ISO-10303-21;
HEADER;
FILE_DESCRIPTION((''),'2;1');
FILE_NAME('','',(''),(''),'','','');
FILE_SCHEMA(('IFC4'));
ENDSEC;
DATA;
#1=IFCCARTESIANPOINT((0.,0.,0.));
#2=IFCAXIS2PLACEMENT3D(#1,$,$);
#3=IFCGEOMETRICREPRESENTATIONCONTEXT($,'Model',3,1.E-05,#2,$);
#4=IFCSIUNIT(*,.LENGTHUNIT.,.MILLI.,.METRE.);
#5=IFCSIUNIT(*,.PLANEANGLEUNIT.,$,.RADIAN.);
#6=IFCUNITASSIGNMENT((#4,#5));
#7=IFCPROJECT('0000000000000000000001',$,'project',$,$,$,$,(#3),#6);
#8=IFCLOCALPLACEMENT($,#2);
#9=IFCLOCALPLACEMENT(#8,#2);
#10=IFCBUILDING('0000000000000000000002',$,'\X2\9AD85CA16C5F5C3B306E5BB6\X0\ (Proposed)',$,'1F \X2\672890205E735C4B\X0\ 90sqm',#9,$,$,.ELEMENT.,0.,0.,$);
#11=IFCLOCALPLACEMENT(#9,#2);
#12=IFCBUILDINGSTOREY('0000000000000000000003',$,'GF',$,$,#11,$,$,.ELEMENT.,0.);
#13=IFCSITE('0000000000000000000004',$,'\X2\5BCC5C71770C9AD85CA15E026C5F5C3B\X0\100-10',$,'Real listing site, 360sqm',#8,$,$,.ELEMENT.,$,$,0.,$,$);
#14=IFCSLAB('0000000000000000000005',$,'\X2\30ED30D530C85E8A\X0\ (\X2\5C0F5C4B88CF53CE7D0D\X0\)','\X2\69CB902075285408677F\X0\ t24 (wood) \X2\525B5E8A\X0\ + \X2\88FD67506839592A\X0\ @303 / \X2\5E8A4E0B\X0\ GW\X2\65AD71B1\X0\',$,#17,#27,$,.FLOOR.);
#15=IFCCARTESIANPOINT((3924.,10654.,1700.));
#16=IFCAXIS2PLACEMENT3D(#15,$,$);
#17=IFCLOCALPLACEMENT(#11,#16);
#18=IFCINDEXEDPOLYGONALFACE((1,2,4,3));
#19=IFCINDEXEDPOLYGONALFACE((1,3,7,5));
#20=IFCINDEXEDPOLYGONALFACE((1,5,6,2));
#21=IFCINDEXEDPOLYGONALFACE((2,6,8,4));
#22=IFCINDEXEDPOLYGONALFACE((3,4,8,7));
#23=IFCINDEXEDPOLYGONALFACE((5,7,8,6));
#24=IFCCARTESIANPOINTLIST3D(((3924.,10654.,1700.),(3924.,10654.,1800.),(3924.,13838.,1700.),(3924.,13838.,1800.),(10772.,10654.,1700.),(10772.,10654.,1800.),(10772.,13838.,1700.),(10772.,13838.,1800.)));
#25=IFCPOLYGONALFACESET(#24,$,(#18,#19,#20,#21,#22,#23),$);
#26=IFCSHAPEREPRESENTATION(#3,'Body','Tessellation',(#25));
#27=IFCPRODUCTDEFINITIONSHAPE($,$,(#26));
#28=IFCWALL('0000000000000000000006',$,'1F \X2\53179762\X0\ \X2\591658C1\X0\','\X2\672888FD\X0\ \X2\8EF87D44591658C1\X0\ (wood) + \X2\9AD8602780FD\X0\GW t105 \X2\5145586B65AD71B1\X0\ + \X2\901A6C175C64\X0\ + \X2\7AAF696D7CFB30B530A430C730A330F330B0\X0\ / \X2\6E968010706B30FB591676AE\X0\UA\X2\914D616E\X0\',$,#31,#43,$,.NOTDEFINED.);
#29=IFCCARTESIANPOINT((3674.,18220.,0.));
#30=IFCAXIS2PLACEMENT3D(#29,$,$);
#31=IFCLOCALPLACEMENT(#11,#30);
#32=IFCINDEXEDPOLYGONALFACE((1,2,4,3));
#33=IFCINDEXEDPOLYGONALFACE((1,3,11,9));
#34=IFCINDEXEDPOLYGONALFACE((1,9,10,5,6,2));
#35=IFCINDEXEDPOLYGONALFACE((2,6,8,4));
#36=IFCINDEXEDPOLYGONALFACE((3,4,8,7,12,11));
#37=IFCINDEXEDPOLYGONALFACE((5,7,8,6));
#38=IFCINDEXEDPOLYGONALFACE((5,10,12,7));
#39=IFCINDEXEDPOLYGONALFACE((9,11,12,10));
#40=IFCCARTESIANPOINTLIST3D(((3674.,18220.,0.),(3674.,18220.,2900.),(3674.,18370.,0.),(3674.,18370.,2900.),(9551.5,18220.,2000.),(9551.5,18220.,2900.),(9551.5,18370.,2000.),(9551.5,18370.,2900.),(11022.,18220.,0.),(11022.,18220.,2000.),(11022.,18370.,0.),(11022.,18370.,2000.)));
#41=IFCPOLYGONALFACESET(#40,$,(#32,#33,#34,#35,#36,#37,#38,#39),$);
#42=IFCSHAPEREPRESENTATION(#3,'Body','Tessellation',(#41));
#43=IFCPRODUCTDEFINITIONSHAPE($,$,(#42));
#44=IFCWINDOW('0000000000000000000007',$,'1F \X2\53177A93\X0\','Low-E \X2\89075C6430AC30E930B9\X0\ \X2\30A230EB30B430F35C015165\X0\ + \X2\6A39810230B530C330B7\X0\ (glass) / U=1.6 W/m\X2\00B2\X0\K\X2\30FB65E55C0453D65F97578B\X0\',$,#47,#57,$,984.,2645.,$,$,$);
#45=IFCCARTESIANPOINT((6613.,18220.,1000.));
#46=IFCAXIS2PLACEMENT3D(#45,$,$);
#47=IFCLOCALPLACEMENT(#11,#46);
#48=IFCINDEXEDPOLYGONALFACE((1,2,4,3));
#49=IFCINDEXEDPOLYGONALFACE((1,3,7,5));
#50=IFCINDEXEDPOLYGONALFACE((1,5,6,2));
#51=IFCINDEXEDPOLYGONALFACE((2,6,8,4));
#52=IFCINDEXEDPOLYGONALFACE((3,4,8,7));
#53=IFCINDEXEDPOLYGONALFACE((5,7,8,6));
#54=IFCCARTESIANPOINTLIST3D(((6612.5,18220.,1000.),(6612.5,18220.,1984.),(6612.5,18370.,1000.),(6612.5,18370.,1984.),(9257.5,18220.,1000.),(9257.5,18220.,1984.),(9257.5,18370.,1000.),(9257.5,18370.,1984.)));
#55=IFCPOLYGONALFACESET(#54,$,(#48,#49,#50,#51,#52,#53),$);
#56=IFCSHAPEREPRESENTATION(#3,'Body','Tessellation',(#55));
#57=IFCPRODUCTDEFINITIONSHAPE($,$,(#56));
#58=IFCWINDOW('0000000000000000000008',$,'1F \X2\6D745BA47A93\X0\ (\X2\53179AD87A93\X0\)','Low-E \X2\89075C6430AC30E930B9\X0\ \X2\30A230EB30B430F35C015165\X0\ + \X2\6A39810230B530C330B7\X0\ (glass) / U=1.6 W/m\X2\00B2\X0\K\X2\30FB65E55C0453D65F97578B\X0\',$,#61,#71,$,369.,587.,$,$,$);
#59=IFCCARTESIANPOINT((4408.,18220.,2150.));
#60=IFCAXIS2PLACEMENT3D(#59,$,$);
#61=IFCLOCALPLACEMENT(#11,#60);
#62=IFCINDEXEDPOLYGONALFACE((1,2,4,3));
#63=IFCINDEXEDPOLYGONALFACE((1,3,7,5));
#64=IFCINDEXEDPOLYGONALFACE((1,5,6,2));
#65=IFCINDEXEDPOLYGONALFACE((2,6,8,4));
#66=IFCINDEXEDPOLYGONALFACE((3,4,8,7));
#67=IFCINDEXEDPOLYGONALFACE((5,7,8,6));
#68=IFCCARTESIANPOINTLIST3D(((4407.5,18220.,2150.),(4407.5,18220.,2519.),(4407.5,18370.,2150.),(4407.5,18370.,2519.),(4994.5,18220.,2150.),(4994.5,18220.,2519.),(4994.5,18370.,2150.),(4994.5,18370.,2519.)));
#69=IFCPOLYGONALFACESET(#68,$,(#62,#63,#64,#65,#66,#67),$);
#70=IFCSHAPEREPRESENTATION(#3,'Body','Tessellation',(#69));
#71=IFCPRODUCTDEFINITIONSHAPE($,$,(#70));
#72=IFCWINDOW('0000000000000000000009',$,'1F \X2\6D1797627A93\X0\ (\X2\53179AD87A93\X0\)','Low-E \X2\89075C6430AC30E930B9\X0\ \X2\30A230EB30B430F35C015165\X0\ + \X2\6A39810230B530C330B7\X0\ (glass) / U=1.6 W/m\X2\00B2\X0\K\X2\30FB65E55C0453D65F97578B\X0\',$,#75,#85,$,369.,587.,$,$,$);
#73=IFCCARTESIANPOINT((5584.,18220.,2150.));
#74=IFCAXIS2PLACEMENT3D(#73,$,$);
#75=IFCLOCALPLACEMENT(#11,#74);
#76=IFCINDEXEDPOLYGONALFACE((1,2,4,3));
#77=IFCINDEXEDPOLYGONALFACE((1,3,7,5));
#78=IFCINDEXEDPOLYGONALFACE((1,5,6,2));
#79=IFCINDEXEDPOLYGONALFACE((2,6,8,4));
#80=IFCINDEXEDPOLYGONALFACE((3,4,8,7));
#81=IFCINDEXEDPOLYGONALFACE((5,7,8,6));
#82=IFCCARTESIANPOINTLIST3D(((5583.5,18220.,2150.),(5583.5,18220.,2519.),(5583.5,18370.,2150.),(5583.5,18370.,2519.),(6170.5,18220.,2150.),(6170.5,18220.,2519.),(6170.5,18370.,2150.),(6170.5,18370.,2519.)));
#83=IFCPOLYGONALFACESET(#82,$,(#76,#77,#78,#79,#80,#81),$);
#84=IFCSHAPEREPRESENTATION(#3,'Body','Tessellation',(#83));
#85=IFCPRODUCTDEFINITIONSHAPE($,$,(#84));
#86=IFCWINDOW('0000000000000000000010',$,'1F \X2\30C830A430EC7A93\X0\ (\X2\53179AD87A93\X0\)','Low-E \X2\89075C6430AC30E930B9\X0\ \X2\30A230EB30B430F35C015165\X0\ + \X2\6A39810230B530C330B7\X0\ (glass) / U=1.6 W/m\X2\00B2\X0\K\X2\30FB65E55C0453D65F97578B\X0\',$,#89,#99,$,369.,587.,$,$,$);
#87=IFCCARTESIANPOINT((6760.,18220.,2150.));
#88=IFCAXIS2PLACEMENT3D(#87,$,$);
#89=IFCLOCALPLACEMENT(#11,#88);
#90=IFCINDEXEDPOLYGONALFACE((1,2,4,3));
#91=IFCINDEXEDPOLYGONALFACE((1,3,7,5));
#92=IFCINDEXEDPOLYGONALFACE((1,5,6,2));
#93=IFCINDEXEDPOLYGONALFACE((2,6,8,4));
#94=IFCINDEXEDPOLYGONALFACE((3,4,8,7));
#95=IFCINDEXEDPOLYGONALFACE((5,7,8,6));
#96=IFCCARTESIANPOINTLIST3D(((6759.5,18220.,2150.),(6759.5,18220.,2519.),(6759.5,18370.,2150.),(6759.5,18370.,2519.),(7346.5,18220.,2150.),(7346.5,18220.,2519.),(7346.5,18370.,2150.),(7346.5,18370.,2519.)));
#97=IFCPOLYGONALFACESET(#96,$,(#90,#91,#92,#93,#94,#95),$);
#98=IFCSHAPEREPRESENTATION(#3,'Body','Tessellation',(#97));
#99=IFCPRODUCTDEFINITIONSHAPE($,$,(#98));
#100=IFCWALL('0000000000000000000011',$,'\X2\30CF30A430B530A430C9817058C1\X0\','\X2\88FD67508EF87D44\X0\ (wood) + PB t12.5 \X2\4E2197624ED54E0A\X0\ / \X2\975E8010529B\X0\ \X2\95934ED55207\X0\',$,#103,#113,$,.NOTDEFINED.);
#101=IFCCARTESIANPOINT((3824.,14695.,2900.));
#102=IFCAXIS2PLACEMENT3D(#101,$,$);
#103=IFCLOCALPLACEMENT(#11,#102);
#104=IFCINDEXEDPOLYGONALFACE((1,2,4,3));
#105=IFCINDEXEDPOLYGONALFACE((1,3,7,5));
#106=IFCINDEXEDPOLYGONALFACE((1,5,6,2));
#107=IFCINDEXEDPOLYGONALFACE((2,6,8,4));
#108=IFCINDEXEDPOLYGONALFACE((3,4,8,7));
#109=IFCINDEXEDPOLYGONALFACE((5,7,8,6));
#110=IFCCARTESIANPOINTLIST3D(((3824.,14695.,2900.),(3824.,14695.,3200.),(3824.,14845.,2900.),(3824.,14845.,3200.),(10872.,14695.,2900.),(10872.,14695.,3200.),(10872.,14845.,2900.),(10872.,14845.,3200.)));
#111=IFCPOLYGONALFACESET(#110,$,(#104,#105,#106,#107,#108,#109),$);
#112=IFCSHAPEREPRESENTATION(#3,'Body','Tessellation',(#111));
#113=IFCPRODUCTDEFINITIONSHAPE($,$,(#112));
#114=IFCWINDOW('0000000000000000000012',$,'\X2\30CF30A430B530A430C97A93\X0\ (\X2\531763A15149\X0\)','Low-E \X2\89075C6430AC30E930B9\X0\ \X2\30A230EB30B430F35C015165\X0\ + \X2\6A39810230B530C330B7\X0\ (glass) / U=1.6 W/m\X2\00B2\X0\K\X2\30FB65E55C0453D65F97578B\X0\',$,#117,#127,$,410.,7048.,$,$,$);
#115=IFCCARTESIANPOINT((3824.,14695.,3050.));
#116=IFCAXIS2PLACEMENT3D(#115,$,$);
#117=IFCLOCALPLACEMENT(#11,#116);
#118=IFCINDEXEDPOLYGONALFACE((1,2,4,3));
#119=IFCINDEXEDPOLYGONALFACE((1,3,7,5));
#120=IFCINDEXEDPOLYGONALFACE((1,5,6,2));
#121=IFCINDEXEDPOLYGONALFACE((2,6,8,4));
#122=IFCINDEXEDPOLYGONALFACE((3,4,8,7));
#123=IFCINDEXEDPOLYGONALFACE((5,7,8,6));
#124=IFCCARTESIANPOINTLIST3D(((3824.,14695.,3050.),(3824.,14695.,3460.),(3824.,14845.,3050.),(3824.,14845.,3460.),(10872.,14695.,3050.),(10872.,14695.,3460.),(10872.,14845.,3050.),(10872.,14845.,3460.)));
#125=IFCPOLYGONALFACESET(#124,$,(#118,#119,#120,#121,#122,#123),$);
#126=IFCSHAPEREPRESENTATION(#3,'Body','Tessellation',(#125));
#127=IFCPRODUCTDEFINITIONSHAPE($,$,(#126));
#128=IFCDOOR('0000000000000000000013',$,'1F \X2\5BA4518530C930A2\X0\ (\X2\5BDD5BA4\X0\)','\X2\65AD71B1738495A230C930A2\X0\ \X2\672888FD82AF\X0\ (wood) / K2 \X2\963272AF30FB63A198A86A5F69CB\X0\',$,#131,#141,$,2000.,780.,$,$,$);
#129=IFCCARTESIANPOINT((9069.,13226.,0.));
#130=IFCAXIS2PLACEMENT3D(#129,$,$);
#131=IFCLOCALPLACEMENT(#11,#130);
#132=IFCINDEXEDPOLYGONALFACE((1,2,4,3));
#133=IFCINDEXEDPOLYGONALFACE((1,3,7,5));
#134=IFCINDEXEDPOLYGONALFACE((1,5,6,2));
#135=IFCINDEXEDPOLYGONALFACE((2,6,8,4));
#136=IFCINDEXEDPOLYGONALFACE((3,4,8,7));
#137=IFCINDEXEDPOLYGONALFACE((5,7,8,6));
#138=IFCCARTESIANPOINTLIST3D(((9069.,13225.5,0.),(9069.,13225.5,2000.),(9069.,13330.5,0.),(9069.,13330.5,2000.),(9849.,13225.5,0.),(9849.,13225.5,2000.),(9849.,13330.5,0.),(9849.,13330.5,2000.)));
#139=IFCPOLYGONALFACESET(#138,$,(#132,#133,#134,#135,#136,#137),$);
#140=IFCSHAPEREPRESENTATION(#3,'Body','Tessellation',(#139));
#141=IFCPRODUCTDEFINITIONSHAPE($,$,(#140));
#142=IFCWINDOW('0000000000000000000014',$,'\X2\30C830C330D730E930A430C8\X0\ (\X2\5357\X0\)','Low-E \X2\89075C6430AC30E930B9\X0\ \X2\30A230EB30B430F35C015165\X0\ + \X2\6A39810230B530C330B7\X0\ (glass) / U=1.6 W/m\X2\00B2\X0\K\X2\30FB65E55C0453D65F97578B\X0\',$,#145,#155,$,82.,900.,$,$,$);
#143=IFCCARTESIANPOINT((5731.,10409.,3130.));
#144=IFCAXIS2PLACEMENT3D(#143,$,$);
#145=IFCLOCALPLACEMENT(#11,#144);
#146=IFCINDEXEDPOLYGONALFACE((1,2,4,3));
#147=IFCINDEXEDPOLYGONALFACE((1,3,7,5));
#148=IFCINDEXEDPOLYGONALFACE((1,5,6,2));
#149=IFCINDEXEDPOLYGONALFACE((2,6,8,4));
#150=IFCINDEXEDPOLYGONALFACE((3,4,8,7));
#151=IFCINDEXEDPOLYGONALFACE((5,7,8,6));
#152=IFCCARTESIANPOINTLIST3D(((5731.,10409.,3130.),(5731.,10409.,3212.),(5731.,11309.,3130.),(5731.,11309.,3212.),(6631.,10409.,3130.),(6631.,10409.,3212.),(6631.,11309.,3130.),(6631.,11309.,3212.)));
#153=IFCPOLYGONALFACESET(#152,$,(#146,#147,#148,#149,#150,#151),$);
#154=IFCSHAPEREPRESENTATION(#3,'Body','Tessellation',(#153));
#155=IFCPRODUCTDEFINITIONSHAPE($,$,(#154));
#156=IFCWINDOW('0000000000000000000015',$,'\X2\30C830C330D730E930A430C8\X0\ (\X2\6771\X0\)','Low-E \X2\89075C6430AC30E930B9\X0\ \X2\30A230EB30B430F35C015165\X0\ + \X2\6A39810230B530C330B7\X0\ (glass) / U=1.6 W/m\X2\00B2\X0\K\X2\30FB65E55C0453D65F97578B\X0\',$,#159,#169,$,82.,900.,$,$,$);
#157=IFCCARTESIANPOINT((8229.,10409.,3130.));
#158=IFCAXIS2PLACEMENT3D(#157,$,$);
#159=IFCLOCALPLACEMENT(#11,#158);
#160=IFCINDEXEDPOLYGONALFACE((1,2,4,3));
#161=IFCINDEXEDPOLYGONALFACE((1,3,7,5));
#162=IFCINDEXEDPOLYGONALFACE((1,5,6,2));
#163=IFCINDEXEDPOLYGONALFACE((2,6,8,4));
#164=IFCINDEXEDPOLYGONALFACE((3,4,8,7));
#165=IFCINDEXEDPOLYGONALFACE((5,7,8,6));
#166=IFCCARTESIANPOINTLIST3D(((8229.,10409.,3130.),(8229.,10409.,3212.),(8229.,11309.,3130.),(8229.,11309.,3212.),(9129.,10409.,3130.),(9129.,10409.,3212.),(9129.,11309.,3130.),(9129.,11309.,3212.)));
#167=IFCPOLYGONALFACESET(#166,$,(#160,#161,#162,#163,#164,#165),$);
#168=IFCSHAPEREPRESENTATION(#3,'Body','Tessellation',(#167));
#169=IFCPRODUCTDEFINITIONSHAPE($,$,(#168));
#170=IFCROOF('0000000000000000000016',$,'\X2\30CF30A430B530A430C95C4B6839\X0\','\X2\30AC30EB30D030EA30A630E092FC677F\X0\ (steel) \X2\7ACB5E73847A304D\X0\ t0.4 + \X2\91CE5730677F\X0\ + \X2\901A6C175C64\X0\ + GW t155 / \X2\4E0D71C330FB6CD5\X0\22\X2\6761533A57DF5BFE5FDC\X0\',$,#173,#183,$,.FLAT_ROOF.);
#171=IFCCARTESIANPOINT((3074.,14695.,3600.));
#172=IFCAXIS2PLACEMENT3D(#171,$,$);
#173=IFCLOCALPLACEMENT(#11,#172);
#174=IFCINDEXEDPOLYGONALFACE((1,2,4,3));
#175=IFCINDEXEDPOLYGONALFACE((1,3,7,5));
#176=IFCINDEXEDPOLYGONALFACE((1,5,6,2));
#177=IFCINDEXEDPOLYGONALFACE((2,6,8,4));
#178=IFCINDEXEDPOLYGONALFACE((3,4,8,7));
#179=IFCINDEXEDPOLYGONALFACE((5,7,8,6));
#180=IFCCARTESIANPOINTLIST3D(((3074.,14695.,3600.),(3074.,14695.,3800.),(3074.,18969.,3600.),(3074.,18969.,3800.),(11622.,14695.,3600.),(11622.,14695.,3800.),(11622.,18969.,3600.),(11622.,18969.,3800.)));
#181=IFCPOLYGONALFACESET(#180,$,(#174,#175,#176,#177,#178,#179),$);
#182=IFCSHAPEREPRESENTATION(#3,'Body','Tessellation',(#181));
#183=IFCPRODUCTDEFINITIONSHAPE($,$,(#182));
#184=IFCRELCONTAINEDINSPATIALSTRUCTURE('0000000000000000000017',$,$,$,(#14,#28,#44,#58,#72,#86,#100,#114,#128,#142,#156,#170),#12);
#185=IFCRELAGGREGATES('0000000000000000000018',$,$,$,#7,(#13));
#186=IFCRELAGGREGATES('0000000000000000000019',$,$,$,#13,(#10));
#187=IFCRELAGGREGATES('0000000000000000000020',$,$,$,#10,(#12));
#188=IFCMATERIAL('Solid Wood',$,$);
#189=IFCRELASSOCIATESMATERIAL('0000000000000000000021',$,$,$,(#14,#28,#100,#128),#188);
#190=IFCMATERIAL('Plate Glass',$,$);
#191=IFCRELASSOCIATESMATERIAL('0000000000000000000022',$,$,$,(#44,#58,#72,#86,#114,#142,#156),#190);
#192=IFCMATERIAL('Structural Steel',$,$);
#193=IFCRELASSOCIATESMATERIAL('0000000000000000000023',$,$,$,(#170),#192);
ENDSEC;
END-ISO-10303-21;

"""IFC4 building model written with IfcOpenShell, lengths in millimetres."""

from ifc_helpers import new_model, si_unit, frame, frame_2d, origin, place, context, project, spatial, rectangle, extrude, material, element, fill, save


model = new_model("IFC4")

# Units and contexts
model_context = context("Model", 3, precision=1e-05, world=origin())
ifc_project = project(units=[si_unit("LENGTHUNIT", "METRE", prefix="MILLI"), si_unit("PLANEANGLEUNIT", "RADIAN")], contexts=[model_context])

# Site, building, storey
site_placement = place(None, origin())
site = spatial("IfcSite", under=ifc_project, at=site_placement, Name="富山県高岡市江尻100-10", ObjectType="Real listing site, 360sqm", CompositionType="ELEMENT", RefElevation=0.0)
building_placement = place(site_placement, origin())
building = spatial("IfcBuilding", under=site, at=building_placement, Name="高岡江尻の家 (Proposed)", ObjectType="1F 木造平屋 90sqm", CompositionType="ELEMENT", ElevationOfRefHeight=0.0, ElevationOfTerrain=0.0)
storey_placement = place(building_placement, origin())
storey = spatial("IfcBuildingStorey", under=building, at=storey_placement, Name="GF", CompositionType="ELEMENT", Elevation=0.0)

# Slab
ifc_material_1 = material(Name="Solid Wood")
slab_placement = place(storey_placement, frame((3924.0, 10654.0, 1700.0)))
element("IfcSlab", 1, at=slab_placement, inside=storey, material=ifc_material_1, Name="ロフト床 (小屋裏収納)", Description="構造用合板 t24 (wood) 剛床 + 製材根太 @303 / 床下 GW断熱", PredefinedType="FLOOR", context=model_context, shape_type="SweptSolid", body=[
    extrude(rectangle(XDim=6848.0, YDim=3184.0, at=frame_2d((3424.0, 1592.0))), frame((3924.0, 10654.0, 1700.0)), (0.0, 0.0, 1.0), 100.0),
])

# Wall, openings, windows
wall_1_placement = place(storey_placement, frame((3674.0, 18220.0, 0.0)))
wall_1 = element("IfcWall", 2, at=wall_1_placement, inside=storey, material=ifc_material_1, Name="1F 北面 外壁", Description="木製 軸組外壁 (wood) + 高性能GW t105 充填断熱 + 通気層 + 窯業系サイディング / 準耐火・外皮UA配慮", PredefinedType="NOTDEFINED", context=model_context, shape_type="SweptSolid", body=[
    extrude(rectangle(XDim=7348.0, YDim=150.0, at=frame_2d((3674.0, 75.0))), frame((3674.0, 18220.0, 0.0)), (0.0, 0.0, 1.0), 2900.0),
])
opening_1_placement = place(storey_placement, frame((6613.0, 18220.0, 1000.0)))
opening_1 = element("IfcOpeningElement", 3, at=opening_1_placement, cuts=wall_1, PredefinedType="NOTDEFINED", context=model_context, shape_type="SweptSolid", body=[
    extrude(rectangle(XDim=2645.0, YDim=150.0, at=frame_2d((1322.0, 75.0))), frame((6613.0, 18220.0, 1000.0)), (0.0, 0.0, 1.0), 984.0),
])
opening_2_placement = place(storey_placement, frame((4408.0, 18220.0, 2150.0)))
opening_2 = element("IfcOpeningElement", 4, at=opening_2_placement, cuts=wall_1, PredefinedType="NOTDEFINED", context=model_context, shape_type="SweptSolid", body=[
    extrude(rectangle(XDim=587.0, YDim=150.0, at=frame_2d((293.0, 75.0))), frame((4408.0, 18220.0, 2150.0)), (0.0, 0.0, 1.0), 369.0),
])
opening_3_placement = place(storey_placement, frame((5584.0, 18220.0, 2150.0)))
opening_3 = element("IfcOpeningElement", 5, at=opening_3_placement, cuts=wall_1, PredefinedType="NOTDEFINED", context=model_context, shape_type="SweptSolid", body=[
    extrude(rectangle(XDim=587.0, YDim=150.0, at=frame_2d((293.0, 75.0))), frame((5584.0, 18220.0, 2150.0)), (0.0, 0.0, 1.0), 369.0),
])
opening_4_placement = place(storey_placement, frame((6760.0, 18220.0, 2150.0)))
opening_4 = element("IfcOpeningElement", 6, at=opening_4_placement, cuts=wall_1, PredefinedType="NOTDEFINED", context=model_context, shape_type="SweptSolid", body=[
    extrude(rectangle(XDim=587.0, YDim=150.0, at=frame_2d((293.0, 75.0))), frame((6760.0, 18220.0, 2150.0)), (0.0, 0.0, 1.0), 369.0),
])
ifc_material_2 = material(Name="Plate Glass")
window_1_placement = place(storey_placement, frame((6613.0, 18220.0, 1000.0)))
window_1 = element("IfcWindow", 7, at=window_1_placement, inside=storey, material=ifc_material_2, Name="1F 北窓", Description="Low-E 複層ガラス アルゴン封入 + 樹脂サッシ (glass) / U=1.6 W/m²K・日射取得型", OverallHeight=984.0, OverallWidth=2645.0, context=model_context, shape_type="SweptSolid", body=[
    extrude(rectangle(XDim=2645.0, YDim=150.0, at=frame_2d((1322.0, 75.0))), frame((6613.0, 18220.0, 1000.0)), (0.0, 0.0, 1.0), 984.0),
])
fill(opening_1, window_1)
window_2_placement = place(storey_placement, frame((4408.0, 18220.0, 2150.0)))
window_2 = element("IfcWindow", 8, at=window_2_placement, inside=storey, material=ifc_material_2, Name="1F 浴室窓 (北高窓)", Description="Low-E 複層ガラス アルゴン封入 + 樹脂サッシ (glass) / U=1.6 W/m²K・日射取得型", OverallHeight=369.0, OverallWidth=587.0, context=model_context, shape_type="SweptSolid", body=[
    extrude(rectangle(XDim=587.0, YDim=150.0, at=frame_2d((293.0, 75.0))), frame((4408.0, 18220.0, 2150.0)), (0.0, 0.0, 1.0), 369.0),
])
fill(opening_2, window_2)
window_3_placement = place(storey_placement, frame((5584.0, 18220.0, 2150.0)))
window_3 = element("IfcWindow", 9, at=window_3_placement, inside=storey, material=ifc_material_2, Name="1F 洗面窓 (北高窓)", Description="Low-E 複層ガラス アルゴン封入 + 樹脂サッシ (glass) / U=1.6 W/m²K・日射取得型", OverallHeight=369.0, OverallWidth=587.0, context=model_context, shape_type="SweptSolid", body=[
    extrude(rectangle(XDim=587.0, YDim=150.0, at=frame_2d((293.0, 75.0))), frame((5584.0, 18220.0, 2150.0)), (0.0, 0.0, 1.0), 369.0),
])
fill(opening_3, window_3)
window_4_placement = place(storey_placement, frame((6760.0, 18220.0, 2150.0)))
window_4 = element("IfcWindow", 10, at=window_4_placement, inside=storey, material=ifc_material_2, Name="1F トイレ窓 (北高窓)", Description="Low-E 複層ガラス アルゴン封入 + 樹脂サッシ (glass) / U=1.6 W/m²K・日射取得型", OverallHeight=369.0, OverallWidth=587.0, context=model_context, shape_type="SweptSolid", body=[
    extrude(rectangle(XDim=587.0, YDim=150.0, at=frame_2d((293.0, 75.0))), frame((6760.0, 18220.0, 2150.0)), (0.0, 0.0, 1.0), 369.0),
])
fill(opening_4, window_4)

# Wall, opening, window
wall_2_placement = place(storey_placement, frame((3824.0, 14695.0, 2900.0)))
wall_2 = element("IfcWall", 11, at=wall_2_placement, inside=storey, material=ifc_material_1, Name="ハイサイド腰壁", Description="製材軸組 (wood) + PB t12.5 両面仕上 / 非耐力 間仕切", PredefinedType="NOTDEFINED", context=model_context, shape_type="SweptSolid", body=[
    extrude(rectangle(XDim=7048.0, YDim=150.0, at=frame_2d((3524.0, 75.0))), frame((3824.0, 14695.0, 2900.0)), (0.0, 0.0, 1.0), 700.0),
])
opening_5_placement = place(storey_placement, frame((3824.0, 14695.0, 3050.0)))
opening_5 = element("IfcOpeningElement", 12, at=opening_5_placement, cuts=wall_2, PredefinedType="NOTDEFINED", context=model_context, shape_type="SweptSolid", body=[
    extrude(rectangle(XDim=7048.0, YDim=150.0, at=frame_2d((3524.0, 75.0))), frame((3824.0, 14695.0, 3050.0)), (0.0, 0.0, 1.0), 410.0),
])
window_5_placement = place(storey_placement, frame((3824.0, 14695.0, 3050.0)))
window_5 = element("IfcWindow", 13, at=window_5_placement, inside=storey, material=ifc_material_2, Name="ハイサイド窓 (北採光)", Description="Low-E 複層ガラス アルゴン封入 + 樹脂サッシ (glass) / U=1.6 W/m²K・日射取得型", OverallHeight=410.0, OverallWidth=7048.0, context=model_context, shape_type="SweptSolid", body=[
    extrude(rectangle(XDim=7048.0, YDim=150.0, at=frame_2d((3524.0, 75.0))), frame((3824.0, 14695.0, 3050.0)), (0.0, 0.0, 1.0), 410.0),
])
fill(opening_5, window_5)

# Door
door_1_placement = place(storey_placement, frame((9069.0, 13226.0, 0.0)))
element("IfcDoor", 14, at=door_1_placement, inside=storey, material=ifc_material_1, Name="1F 室内ドア (寝室)", Description="断熱玄関ドア 木製芯 (wood) / K2 防犯・採風機構", OverallHeight=2000.0, OverallWidth=780.0, context=model_context, shape_type="SweptSolid", body=[
    extrude(rectangle(XDim=780.0, YDim=105.0, at=frame_2d((390.0, 52.0))), frame((9069.0, 13226.0, 0.0)), (0.0, 0.0, 1.0), 2000.0),
])

# Windows
window_6_placement = place(storey_placement, frame((5731.0, 10409.0, 3130.0)))
element("IfcWindow", 15, at=window_6_placement, inside=storey, material=ifc_material_2, Name="トップライト (南)", Description="Low-E 複層ガラス アルゴン封入 + 樹脂サッシ (glass) / U=1.6 W/m²K・日射取得型", OverallHeight=82.0, OverallWidth=900.0, context=model_context, shape_type="SweptSolid", body=[
    extrude(rectangle(XDim=900.0, YDim=900.0, at=frame_2d((450.0, 450.0))), frame((5731.0, 10409.0, 3130.0)), (0.0, 0.0, 1.0), 82.0),
])
window_7_placement = place(storey_placement, frame((8229.0, 10409.0, 3130.0)))
element("IfcWindow", 16, at=window_7_placement, inside=storey, material=ifc_material_2, Name="トップライト (東)", Description="Low-E 複層ガラス アルゴン封入 + 樹脂サッシ (glass) / U=1.6 W/m²K・日射取得型", OverallHeight=82.0, OverallWidth=900.0, context=model_context, shape_type="SweptSolid", body=[
    extrude(rectangle(XDim=900.0, YDim=900.0, at=frame_2d((450.0, 450.0))), frame((8229.0, 10409.0, 3130.0)), (0.0, 0.0, 1.0), 82.0),
])

# Roof
ifc_material_3 = material(Name="Structural Steel")
roof_placement = place(storey_placement, frame((3074.0, 14695.0, 3600.0)))
element("IfcRoof", 17, at=roof_placement, inside=storey, material=ifc_material_3, Name="ハイサイド屋根", Description="ガルバリウム鋼板 (steel) 立平葺き t0.4 + 野地板 + 通気層 + GW t155 / 不燃・法22条区域対応", PredefinedType="FLAT_ROOF", context=model_context, shape_type="SweptSolid", body=[
    extrude(rectangle(XDim=8548.0, YDim=4274.0, at=frame_2d((4274.0, 2137.0))), frame((3074.0, 14695.0, 3600.0)), (0.0, 0.0, 1.0), 200.0),
])

save(model, "model.ifc")
